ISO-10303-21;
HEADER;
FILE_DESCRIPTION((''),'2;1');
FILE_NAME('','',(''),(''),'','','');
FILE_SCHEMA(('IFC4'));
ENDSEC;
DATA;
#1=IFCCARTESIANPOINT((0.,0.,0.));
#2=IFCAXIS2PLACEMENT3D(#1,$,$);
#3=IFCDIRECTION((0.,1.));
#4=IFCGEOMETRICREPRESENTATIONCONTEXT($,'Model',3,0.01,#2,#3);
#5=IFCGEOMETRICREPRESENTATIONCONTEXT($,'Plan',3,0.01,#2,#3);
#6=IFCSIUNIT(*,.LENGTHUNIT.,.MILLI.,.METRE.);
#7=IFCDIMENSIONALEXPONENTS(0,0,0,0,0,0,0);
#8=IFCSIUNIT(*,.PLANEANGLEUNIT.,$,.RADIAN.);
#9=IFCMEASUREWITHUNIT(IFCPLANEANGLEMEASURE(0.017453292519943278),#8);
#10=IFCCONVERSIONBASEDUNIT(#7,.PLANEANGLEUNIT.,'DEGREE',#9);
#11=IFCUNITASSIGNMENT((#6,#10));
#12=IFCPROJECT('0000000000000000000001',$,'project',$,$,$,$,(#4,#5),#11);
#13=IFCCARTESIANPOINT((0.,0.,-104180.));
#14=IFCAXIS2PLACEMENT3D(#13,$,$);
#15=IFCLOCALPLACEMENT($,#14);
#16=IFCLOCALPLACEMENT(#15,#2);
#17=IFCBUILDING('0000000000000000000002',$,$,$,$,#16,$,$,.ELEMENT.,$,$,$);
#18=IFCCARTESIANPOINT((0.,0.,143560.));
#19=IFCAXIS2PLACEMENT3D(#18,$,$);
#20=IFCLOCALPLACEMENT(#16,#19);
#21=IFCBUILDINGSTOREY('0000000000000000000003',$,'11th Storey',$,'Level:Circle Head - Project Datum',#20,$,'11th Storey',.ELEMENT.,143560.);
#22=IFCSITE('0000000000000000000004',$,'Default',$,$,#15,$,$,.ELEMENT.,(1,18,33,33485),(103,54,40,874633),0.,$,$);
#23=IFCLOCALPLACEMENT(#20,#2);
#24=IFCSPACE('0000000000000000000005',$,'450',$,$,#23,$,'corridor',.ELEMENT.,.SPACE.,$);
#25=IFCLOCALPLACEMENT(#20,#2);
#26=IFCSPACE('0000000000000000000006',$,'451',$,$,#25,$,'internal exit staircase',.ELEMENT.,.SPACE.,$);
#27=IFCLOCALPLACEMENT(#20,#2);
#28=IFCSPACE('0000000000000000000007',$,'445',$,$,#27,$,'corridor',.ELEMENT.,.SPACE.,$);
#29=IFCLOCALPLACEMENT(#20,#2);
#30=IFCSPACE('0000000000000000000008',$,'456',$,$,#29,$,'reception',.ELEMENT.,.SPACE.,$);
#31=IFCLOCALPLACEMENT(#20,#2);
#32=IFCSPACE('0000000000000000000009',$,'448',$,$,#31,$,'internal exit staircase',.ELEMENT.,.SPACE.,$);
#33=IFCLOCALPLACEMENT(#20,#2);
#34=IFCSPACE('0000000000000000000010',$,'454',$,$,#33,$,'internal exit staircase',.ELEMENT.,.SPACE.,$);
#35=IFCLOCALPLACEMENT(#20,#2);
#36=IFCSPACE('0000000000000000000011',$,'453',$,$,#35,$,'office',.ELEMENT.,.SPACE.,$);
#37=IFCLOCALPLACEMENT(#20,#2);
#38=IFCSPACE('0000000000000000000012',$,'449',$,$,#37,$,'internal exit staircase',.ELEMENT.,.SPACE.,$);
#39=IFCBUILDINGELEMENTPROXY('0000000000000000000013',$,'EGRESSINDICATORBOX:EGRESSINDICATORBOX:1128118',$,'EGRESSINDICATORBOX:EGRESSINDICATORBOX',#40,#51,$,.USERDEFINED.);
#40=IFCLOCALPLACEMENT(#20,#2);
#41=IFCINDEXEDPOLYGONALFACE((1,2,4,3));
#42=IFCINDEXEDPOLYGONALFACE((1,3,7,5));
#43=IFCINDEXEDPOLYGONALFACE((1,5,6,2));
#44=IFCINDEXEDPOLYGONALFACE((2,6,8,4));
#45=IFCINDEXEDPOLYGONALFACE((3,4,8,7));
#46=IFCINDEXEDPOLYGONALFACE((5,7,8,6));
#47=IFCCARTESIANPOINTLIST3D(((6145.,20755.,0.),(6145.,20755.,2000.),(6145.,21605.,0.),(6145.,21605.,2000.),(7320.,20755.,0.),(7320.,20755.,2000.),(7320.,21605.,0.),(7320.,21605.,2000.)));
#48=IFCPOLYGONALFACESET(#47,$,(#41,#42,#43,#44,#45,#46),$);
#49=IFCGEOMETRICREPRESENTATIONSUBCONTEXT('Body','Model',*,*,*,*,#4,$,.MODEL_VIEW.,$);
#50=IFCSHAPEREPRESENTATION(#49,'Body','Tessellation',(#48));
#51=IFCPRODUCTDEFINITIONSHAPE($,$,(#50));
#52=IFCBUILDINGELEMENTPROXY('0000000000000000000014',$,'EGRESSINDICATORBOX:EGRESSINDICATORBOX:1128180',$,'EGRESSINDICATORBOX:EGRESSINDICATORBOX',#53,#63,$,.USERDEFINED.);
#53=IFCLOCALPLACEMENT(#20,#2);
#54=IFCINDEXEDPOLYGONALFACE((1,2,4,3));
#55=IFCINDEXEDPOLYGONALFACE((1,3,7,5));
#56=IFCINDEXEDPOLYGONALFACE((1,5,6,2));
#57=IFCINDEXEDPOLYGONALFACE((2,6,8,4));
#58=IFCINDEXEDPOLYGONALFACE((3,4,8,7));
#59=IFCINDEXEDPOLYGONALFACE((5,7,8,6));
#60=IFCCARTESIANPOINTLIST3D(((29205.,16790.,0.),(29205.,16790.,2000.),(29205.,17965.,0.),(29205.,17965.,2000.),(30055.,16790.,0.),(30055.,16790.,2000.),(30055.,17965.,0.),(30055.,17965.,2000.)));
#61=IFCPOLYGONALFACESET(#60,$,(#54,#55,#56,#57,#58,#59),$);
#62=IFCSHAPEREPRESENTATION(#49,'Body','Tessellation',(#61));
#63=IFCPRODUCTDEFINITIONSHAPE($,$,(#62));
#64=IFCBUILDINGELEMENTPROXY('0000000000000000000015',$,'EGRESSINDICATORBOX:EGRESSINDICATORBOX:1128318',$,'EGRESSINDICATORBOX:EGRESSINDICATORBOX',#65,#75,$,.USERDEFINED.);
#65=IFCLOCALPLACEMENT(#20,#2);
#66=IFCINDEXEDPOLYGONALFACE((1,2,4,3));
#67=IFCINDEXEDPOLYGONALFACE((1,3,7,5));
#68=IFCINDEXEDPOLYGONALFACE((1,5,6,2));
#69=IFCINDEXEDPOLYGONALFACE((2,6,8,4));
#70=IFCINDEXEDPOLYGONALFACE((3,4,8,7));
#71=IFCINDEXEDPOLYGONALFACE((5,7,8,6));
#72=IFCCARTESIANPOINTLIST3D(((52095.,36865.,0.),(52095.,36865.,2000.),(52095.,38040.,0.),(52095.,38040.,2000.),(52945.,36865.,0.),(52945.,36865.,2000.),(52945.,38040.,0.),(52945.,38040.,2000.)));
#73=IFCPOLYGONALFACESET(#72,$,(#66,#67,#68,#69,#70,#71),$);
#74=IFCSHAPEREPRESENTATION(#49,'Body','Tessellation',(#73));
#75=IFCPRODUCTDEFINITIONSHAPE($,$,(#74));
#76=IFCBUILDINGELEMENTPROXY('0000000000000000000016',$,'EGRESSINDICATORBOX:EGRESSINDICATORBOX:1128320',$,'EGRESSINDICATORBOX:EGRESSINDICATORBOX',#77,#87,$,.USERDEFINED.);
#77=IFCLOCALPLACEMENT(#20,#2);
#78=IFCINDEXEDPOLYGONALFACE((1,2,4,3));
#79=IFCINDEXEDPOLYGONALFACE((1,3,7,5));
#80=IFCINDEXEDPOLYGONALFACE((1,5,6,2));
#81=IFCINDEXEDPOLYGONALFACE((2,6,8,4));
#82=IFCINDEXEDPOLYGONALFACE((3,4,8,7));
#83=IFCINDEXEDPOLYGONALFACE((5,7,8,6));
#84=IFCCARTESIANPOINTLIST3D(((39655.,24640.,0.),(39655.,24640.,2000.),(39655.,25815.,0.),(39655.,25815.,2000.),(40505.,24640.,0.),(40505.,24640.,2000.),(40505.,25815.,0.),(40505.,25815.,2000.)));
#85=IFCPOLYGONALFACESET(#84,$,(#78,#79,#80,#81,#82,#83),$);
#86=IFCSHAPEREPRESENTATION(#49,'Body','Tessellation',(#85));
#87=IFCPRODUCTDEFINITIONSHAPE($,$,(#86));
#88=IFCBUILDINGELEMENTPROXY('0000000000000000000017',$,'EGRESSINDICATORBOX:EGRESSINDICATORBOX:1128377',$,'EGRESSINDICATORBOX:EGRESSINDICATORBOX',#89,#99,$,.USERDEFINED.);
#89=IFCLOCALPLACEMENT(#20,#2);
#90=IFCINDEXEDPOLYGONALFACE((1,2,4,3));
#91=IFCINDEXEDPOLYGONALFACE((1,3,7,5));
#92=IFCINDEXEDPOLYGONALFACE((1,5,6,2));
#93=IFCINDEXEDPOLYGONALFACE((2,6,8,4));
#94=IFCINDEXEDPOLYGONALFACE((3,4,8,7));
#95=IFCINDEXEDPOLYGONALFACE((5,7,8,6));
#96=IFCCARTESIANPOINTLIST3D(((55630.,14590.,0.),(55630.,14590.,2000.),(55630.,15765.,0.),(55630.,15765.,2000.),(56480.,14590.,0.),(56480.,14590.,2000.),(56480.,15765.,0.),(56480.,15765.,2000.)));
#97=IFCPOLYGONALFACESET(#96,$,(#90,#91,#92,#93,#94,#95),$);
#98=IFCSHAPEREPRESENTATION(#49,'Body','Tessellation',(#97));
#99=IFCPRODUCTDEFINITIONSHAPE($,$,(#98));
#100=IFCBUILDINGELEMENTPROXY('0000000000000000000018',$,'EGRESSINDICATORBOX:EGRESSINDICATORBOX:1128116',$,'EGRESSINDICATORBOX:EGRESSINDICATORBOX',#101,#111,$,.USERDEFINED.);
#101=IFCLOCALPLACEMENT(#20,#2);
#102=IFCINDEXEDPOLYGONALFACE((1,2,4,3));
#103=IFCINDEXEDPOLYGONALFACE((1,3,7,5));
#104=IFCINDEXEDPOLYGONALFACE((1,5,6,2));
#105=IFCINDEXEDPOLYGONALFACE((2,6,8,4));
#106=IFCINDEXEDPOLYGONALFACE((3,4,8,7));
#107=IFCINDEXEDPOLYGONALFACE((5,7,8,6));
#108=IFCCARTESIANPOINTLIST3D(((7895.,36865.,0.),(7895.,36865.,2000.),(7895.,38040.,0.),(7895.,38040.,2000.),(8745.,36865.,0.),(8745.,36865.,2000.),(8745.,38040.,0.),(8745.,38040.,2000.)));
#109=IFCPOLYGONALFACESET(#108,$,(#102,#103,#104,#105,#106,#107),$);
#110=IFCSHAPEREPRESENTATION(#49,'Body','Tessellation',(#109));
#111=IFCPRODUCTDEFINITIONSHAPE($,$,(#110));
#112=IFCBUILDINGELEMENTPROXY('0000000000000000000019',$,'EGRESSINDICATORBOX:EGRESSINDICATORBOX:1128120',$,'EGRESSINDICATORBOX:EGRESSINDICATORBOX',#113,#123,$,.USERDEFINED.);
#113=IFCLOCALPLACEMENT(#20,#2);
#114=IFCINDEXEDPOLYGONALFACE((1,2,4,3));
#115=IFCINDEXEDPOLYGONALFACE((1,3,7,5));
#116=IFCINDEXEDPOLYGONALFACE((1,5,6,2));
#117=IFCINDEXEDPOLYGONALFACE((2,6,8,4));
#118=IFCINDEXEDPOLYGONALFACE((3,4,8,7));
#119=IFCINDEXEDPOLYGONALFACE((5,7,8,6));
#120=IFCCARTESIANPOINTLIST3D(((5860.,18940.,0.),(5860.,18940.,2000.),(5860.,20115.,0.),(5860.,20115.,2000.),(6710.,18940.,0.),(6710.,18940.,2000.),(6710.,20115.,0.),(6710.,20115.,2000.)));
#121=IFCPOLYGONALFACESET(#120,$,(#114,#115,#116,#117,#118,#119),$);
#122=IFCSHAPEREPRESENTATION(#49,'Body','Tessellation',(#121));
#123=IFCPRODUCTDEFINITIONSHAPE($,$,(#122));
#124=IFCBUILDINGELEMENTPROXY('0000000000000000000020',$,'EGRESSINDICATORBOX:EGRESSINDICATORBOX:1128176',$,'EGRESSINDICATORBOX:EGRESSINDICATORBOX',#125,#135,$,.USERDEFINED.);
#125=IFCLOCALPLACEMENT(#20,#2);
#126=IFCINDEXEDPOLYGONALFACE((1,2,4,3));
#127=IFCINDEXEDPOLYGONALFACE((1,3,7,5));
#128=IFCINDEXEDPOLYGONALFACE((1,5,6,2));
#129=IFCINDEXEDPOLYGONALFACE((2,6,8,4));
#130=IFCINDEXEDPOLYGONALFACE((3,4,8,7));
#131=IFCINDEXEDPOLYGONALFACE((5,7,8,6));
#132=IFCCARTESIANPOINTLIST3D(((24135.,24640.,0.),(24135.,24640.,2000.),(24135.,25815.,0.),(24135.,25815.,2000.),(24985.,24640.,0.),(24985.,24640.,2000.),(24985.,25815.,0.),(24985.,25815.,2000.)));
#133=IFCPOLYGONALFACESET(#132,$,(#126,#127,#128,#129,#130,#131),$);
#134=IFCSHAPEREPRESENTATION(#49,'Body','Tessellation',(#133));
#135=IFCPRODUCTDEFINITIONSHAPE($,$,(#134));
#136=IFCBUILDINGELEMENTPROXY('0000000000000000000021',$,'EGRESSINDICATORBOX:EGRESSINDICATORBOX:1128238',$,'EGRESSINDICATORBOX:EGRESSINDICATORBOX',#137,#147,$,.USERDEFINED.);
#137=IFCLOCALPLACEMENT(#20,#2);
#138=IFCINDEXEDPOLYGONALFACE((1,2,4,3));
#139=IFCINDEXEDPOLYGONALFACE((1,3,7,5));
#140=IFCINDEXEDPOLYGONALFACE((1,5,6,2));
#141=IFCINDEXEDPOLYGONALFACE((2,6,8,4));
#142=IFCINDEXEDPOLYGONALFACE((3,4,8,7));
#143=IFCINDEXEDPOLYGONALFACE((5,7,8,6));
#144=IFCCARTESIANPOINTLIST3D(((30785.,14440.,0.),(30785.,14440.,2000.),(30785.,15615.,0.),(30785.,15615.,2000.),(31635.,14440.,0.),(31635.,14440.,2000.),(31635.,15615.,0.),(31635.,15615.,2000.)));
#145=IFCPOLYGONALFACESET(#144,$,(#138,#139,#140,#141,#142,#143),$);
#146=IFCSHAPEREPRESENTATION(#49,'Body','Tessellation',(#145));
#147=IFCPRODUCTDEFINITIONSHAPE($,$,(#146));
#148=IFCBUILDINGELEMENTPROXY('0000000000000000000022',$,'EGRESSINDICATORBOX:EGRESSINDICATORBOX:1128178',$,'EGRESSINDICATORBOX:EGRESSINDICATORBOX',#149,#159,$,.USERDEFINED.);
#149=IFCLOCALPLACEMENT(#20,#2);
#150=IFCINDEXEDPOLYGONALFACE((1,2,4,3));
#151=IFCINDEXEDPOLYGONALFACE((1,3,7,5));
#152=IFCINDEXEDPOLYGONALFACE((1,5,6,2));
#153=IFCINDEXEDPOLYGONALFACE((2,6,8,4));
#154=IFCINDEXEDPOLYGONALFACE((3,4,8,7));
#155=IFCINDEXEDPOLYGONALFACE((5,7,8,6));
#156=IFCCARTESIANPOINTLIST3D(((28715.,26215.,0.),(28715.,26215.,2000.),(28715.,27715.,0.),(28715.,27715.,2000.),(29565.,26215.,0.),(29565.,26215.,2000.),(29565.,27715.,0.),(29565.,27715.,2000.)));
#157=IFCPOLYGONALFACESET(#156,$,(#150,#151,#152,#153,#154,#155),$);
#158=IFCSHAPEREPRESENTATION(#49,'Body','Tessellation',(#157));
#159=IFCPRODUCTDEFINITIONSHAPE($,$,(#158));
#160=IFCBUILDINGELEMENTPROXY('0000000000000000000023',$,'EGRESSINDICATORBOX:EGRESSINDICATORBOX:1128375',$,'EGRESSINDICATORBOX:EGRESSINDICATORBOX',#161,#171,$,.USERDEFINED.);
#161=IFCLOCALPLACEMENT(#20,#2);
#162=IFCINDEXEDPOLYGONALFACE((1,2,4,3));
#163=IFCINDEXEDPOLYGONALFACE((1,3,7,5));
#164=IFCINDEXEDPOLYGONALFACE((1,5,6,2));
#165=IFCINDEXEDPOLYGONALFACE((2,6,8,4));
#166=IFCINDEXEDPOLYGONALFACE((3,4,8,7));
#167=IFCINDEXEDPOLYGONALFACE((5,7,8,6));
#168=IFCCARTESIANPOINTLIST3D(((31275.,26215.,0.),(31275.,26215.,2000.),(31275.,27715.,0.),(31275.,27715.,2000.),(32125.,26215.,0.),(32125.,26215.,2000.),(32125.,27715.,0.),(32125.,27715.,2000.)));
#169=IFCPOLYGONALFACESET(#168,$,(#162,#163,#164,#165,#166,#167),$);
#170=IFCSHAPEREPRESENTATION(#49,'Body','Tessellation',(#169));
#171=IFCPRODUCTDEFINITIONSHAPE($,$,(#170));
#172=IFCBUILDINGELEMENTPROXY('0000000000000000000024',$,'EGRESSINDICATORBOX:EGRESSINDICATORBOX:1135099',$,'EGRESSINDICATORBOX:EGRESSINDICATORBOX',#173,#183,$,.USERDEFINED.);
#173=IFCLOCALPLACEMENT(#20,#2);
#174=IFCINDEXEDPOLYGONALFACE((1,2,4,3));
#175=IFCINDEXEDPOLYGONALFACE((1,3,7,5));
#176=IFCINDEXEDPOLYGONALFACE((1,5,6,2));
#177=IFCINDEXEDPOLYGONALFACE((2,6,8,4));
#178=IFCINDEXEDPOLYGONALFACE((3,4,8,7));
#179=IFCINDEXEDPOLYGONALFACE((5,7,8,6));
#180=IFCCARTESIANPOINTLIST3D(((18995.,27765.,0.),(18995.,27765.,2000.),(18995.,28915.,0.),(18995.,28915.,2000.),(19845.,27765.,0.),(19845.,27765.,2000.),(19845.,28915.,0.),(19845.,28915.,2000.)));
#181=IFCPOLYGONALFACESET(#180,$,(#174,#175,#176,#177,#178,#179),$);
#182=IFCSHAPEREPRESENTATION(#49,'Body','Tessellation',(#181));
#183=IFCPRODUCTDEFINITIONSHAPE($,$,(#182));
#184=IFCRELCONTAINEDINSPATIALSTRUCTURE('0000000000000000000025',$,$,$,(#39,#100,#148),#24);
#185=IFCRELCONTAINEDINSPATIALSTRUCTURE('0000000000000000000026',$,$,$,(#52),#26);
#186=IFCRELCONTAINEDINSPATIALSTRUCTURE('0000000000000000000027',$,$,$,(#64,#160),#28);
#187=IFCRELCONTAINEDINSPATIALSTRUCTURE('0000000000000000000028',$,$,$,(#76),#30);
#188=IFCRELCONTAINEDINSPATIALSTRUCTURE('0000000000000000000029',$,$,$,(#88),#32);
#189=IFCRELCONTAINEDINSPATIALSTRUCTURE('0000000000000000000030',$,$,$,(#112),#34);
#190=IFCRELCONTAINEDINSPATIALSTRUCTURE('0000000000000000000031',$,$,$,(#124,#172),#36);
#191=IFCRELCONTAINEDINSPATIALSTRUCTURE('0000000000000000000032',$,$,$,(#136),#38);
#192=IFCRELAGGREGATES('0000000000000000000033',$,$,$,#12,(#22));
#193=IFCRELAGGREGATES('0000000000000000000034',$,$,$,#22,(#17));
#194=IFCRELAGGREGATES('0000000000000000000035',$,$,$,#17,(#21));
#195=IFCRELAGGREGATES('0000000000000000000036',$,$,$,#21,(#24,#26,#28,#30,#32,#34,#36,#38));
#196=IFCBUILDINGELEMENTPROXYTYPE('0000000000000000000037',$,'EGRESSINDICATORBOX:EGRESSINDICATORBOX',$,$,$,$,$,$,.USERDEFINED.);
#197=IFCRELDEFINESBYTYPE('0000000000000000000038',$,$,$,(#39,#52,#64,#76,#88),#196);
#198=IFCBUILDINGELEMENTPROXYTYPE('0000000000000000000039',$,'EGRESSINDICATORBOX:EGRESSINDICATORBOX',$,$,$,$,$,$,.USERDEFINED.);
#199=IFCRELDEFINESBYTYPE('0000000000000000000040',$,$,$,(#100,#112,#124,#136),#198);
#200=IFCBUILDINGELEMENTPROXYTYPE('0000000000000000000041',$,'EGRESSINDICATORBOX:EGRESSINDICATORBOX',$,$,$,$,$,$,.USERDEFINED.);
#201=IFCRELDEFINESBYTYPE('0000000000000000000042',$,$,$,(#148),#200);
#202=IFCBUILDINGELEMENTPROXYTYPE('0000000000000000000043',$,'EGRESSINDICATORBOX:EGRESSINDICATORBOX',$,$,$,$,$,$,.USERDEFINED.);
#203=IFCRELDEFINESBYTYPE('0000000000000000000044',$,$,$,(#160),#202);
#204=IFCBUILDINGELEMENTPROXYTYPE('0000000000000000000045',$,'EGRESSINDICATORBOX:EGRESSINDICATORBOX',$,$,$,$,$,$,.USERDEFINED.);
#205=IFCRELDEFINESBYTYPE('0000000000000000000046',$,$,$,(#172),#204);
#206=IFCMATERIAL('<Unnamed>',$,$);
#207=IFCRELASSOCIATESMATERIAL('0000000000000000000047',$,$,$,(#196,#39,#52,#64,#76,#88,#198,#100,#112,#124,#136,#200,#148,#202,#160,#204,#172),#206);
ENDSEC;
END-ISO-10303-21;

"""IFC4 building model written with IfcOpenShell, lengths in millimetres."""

from ifc_helpers import new_model, entity, si_unit, converted_unit, direction, frame, origin, place, context, subcontext, project, spatial, indexed_curve, outline, extrude, source, transform, mapped, material, type_object, type_shapes, element, save


model = new_model("IFC4")

# Units and contexts
model_context = context("Model", 3, precision=0.01, world=origin(), true_north=direction((0.0, 1.0)))
plan_context = context("Plan", 3, precision=0.01, world=origin(), true_north=direction((0.0, 1.0)))
body_context = subcontext(model_context, "Body", "Model", "MODEL_VIEW")
ifc_project = project(units=[si_unit("LENGTHUNIT", "METRE", prefix="MILLI"), converted_unit("PLANEANGLEUNIT", "DEGREE", entity("IfcPlaneAngleMeasure", 0.017453292519943278), si_unit("PLANEANGLEUNIT", "RADIAN"), dimensions=[0, 0, 0, 0, 0, 0, 0])], contexts=[model_context, plan_context])

# Site, building, storey
site_placement = place(None, frame((0.0, 0.0, -104180.0)))
site = spatial("IfcSite", under=ifc_project, at=site_placement, Name="Default", CompositionType="ELEMENT", RefLatitude=(1, 18, 33, 33485), RefLongitude=(103, 54, 40, 874633), RefElevation=0.0)
building_placement = place(site_placement, origin())
building = spatial("IfcBuilding", under=site, at=building_placement, CompositionType="ELEMENT")
storey_placement = place(building_placement, frame((0.0, 0.0, 143560.0)))
storey = spatial("IfcBuildingStorey", under=building, at=storey_placement, Name="11th Storey", ObjectType="Level:Circle Head - Project Datum", LongName="11th Storey", CompositionType="ELEMENT", Elevation=143560.0)

# Shared definitions
space_1_placement = place(storey_placement, origin())
space_1 = spatial("IfcSpace", under=storey, at=space_1_placement, Name="450", LongName="corridor", CompositionType="ELEMENT", PredefinedType="SPACE")

# Building element proxy
ifc_material_1 = material(Name="<Unnamed>")
building_element_proxy_type_1 = type_object("IfcBuildingElementProxyType", Name="EGRESSINDICATORBOX:EGRESSINDICATORBOX", PredefinedType="USERDEFINED", material=ifc_material_1)
shared_shape_1 = source(origin(), body_context, "Body", "SweptSolid", [
    extrude(outline(indexed_curve([(-587.5, -425.0), (587.5, -425.0), (587.5, 425.0), (-587.5, 425.0), (-587.5, -425.0)], self_intersect=False)), frame((0.0, 0.0, 0.0), z_axis=(0.0, 0.0, 1.0), x_axis=(0.0, 1.0, 0.0)), (0.0, 0.0, 1.0), 2000.0),
])
type_shapes(building_element_proxy_type_1, [shared_shape_1])
proxy_1_placement = place(space_1_placement, frame((6732.5, 21180.0, 0.0), z_axis=(0.0, 0.0, 1.0), x_axis=(0.0, -1.0, 0.0)))
element("IfcBuildingElementProxy", 1, at=proxy_1_placement, inside=space_1, type_object=building_element_proxy_type_1, material=ifc_material_1, Name="EGRESSINDICATORBOX:EGRESSINDICATORBOX:1128118", ObjectType="EGRESSINDICATORBOX:EGRESSINDICATORBOX", PredefinedType="USERDEFINED", context=body_context, shape_type="MappedRepresentation", body=[
    mapped(shared_shape_1, transform((0.0, 0.0, 0.0), scale=1.0)),
])

# Shared definitions
space_2_placement = place(storey_placement, origin())
space_2 = spatial("IfcSpace", under=storey, at=space_2_placement, Name="451", LongName="internal exit staircase", CompositionType="ELEMENT", PredefinedType="SPACE")

# Building element proxy
proxy_2_placement = place(space_2_placement, frame((29630.0, 17377.5, 0.0)))
element("IfcBuildingElementProxy", 2, at=proxy_2_placement, inside=space_2, type_object=building_element_proxy_type_1, material=ifc_material_1, Name="EGRESSINDICATORBOX:EGRESSINDICATORBOX:1128180", ObjectType="EGRESSINDICATORBOX:EGRESSINDICATORBOX", PredefinedType="USERDEFINED", context=body_context, shape_type="MappedRepresentation", body=[
    mapped(shared_shape_1, transform((0.0, 0.0, 0.0), scale=1.0)),
])

# Shared definitions
space_3_placement = place(storey_placement, origin())
space_3 = spatial("IfcSpace", under=storey, at=space_3_placement, Name="445", LongName="corridor", CompositionType="ELEMENT", PredefinedType="SPACE")

# Building element proxy
proxy_3_placement = place(space_3_placement, frame((52520.0, 37452.5, 0.0), z_axis=(0.0, 0.0, 1.0), x_axis=(-1.0, 0.0, 0.0)))
element("IfcBuildingElementProxy", 3, at=proxy_3_placement, inside=space_3, type_object=building_element_proxy_type_1, material=ifc_material_1, Name="EGRESSINDICATORBOX:EGRESSINDICATORBOX:1128318", ObjectType="EGRESSINDICATORBOX:EGRESSINDICATORBOX", PredefinedType="USERDEFINED", context=body_context, shape_type="MappedRepresentation", body=[
    mapped(shared_shape_1, transform((0.0, 0.0, 0.0), scale=1.0)),
])

# Shared definitions
space_4_placement = place(storey_placement, origin())
space_4 = spatial("IfcSpace", under=storey, at=space_4_placement, Name="456", LongName="reception", CompositionType="ELEMENT", PredefinedType="SPACE")

# Building element proxy
proxy_4_placement = place(space_4_placement, frame((40080.0, 25227.5, 0.0), z_axis=(0.0, 0.0, 1.0), x_axis=(-1.0, 0.0, 0.0)))
element("IfcBuildingElementProxy", 4, at=proxy_4_placement, inside=space_4, type_object=building_element_proxy_type_1, material=ifc_material_1, Name="EGRESSINDICATORBOX:EGRESSINDICATORBOX:1128320", ObjectType="EGRESSINDICATORBOX:EGRESSINDICATORBOX", PredefinedType="USERDEFINED", context=body_context, shape_type="MappedRepresentation", body=[
    mapped(shared_shape_1, transform((0.0, 0.0, 0.0), scale=1.0)),
])

# Shared definitions
space_5_placement = place(storey_placement, origin())
space_5 = spatial("IfcSpace", under=storey, at=space_5_placement, Name="448", LongName="internal exit staircase", CompositionType="ELEMENT", PredefinedType="SPACE")

# Building element proxies
proxy_5_placement = place(space_5_placement, frame((56055.0, 15177.5, 0.0)))
element("IfcBuildingElementProxy", 5, at=proxy_5_placement, inside=space_5, type_object=building_element_proxy_type_1, material=ifc_material_1, Name="EGRESSINDICATORBOX:EGRESSINDICATORBOX:1128377", ObjectType="EGRESSINDICATORBOX:EGRESSINDICATORBOX", PredefinedType="USERDEFINED", context=body_context, shape_type="MappedRepresentation", body=[
    mapped(shared_shape_1, transform((0.0, 0.0, 0.0), scale=1.0)),
])
building_element_proxy_type_2 = type_object("IfcBuildingElementProxyType", Name="EGRESSINDICATORBOX:EGRESSINDICATORBOX", PredefinedType="USERDEFINED", material=ifc_material_1)
shared_shape_2 = source(origin(), body_context, "Body", "SweptSolid", [
    extrude(outline(indexed_curve([(-425.0, -587.5), (425.0, -587.5), (425.0, 587.5), (-425.0, 587.5), (-425.0, -587.5)], self_intersect=False)), frame((0.0, 0.0, 0.0), z_axis=(0.0, 0.0, 1.0), x_axis=(-1.0, 0.0, 0.0)), (0.0, 0.0, 1.0), 2000.0),
])
type_shapes(building_element_proxy_type_2, [shared_shape_2])
proxy_6_placement = place(space_1_placement, frame((8320.0, 37452.5, 0.0)))
element("IfcBuildingElementProxy", 6, at=proxy_6_placement, inside=space_1, type_object=building_element_proxy_type_2, material=ifc_material_1, Name="EGRESSINDICATORBOX:EGRESSINDICATORBOX:1128116", ObjectType="EGRESSINDICATORBOX:EGRESSINDICATORBOX", PredefinedType="USERDEFINED", context=body_context, shape_type="MappedRepresentation", body=[
    mapped(shared_shape_2, transform((0.0, 0.0, 0.0), scale=1.0)),
])

# Shared definitions
space_6_placement = place(storey_placement, origin())
space_6 = spatial("IfcSpace", under=storey, at=space_6_placement, Name="454", LongName="internal exit staircase", CompositionType="ELEMENT", PredefinedType="SPACE")

# Building element proxy
proxy_7_placement = place(space_6_placement, frame((6285.0, 19527.5, 0.0), z_axis=(0.0, 0.0, 1.0), x_axis=(-1.0, 0.0, 0.0)))
element("IfcBuildingElementProxy", 7, at=proxy_7_placement, inside=space_6, type_object=building_element_proxy_type_2, material=ifc_material_1, Name="EGRESSINDICATORBOX:EGRESSINDICATORBOX:1128120", ObjectType="EGRESSINDICATORBOX:EGRESSINDICATORBOX", PredefinedType="USERDEFINED", context=body_context, shape_type="MappedRepresentation", body=[
    mapped(shared_shape_2, transform((0.0, 0.0, 0.0), scale=1.0)),
])

# Shared definitions
space_7_placement = place(storey_placement, origin())
space_7 = spatial("IfcSpace", under=storey, at=space_7_placement, Name="453", LongName="office", CompositionType="ELEMENT", PredefinedType="SPACE")

# Building element proxy
proxy_8_placement = place(space_7_placement, frame((24560.0, 25227.5, 0.0)))
element("IfcBuildingElementProxy", 8, at=proxy_8_placement, inside=space_7, type_object=building_element_proxy_type_2, material=ifc_material_1, Name="EGRESSINDICATORBOX:EGRESSINDICATORBOX:1128176", ObjectType="EGRESSINDICATORBOX:EGRESSINDICATORBOX", PredefinedType="USERDEFINED", context=body_context, shape_type="MappedRepresentation", body=[
    mapped(shared_shape_2, transform((0.0, 0.0, 0.0), scale=1.0)),
])

# Shared definitions
space_8_placement = place(storey_placement, origin())
space_8 = spatial("IfcSpace", under=storey, at=space_8_placement, Name="449", LongName="internal exit staircase", CompositionType="ELEMENT", PredefinedType="SPACE")

# Building element proxies
proxy_9_placement = place(space_8_placement, frame((31210.0, 15027.5, 0.0), z_axis=(0.0, 0.0, 1.0), x_axis=(-1.0, 0.0, 0.0)))
element("IfcBuildingElementProxy", 9, at=proxy_9_placement, inside=space_8, type_object=building_element_proxy_type_2, material=ifc_material_1, Name="EGRESSINDICATORBOX:EGRESSINDICATORBOX:1128238", ObjectType="EGRESSINDICATORBOX:EGRESSINDICATORBOX", PredefinedType="USERDEFINED", context=body_context, shape_type="MappedRepresentation", body=[
    mapped(shared_shape_2, transform((0.0, 0.0, 0.0), scale=1.0)),
])
building_element_proxy_type_3 = type_object("IfcBuildingElementProxyType", Name="EGRESSINDICATORBOX:EGRESSINDICATORBOX", PredefinedType="USERDEFINED", material=ifc_material_1)
shared_shape_3 = source(origin(), body_context, "Body", "SweptSolid", [
    extrude(outline(indexed_curve([(-425.0, -750.0), (425.0, -750.0), (425.0, 750.0), (-425.0, 750.0), (-425.0, -750.0)], self_intersect=False)), frame((0.0, 0.0, 0.0), z_axis=(0.0, 0.0, 1.0), x_axis=(-1.0, 0.0, 0.0)), (0.0, 0.0, 1.0), 2000.0),
])
type_shapes(building_element_proxy_type_3, [shared_shape_3])
proxy_10_placement = place(space_1_placement, frame((29140.0, 26965.0, 0.0)))
element("IfcBuildingElementProxy", 10, at=proxy_10_placement, inside=space_1, type_object=building_element_proxy_type_3, material=ifc_material_1, Name="EGRESSINDICATORBOX:EGRESSINDICATORBOX:1128178", ObjectType="EGRESSINDICATORBOX:EGRESSINDICATORBOX", PredefinedType="USERDEFINED", context=body_context, shape_type="MappedRepresentation", body=[
    mapped(shared_shape_3, transform((0.0, 0.0, 0.0), scale=1.0)),
])
building_element_proxy_type_4 = type_object("IfcBuildingElementProxyType", Name="EGRESSINDICATORBOX:EGRESSINDICATORBOX", PredefinedType="USERDEFINED", material=ifc_material_1)
shared_shape_4 = source(origin(), body_context, "Body", "SweptSolid", [
    extrude(outline(indexed_curve([(-750.0, -425.0), (750.0, -425.0), (750.0, 425.0), (-750.0, 425.0), (-750.0, -425.0)], self_intersect=False)), frame((0.0, 0.0, 0.0), z_axis=(0.0, 0.0, 1.0), x_axis=(0.0, 1.0, 0.0)), (0.0, 0.0, 1.0), 2000.0),
])
type_shapes(building_element_proxy_type_4, [shared_shape_4])
proxy_11_placement = place(space_3_placement, frame((31700.0, 26965.0, 0.0), z_axis=(0.0, 0.0, 1.0), x_axis=(-1.0, 0.0, 0.0)))
element("IfcBuildingElementProxy", 11, at=proxy_11_placement, inside=space_3, type_object=building_element_proxy_type_4, material=ifc_material_1, Name="EGRESSINDICATORBOX:EGRESSINDICATORBOX:1128375", ObjectType="EGRESSINDICATORBOX:EGRESSINDICATORBOX", PredefinedType="USERDEFINED", context=body_context, shape_type="MappedRepresentation", body=[
    mapped(shared_shape_4, transform((0.0, 0.0, 0.0), scale=1.0)),
])
building_element_proxy_type_5 = type_object("IfcBuildingElementProxyType", Name="EGRESSINDICATORBOX:EGRESSINDICATORBOX", PredefinedType="USERDEFINED", material=ifc_material_1)
shared_shape_5 = source(origin(), body_context, "Body", "SweptSolid", [
    extrude(outline(indexed_curve([(-425.0, -575.0), (425.0, -575.0), (425.0, 575.0), (-425.0, 575.0), (-425.0, -575.0)], self_intersect=False)), frame((0.0, 0.0, 0.0), z_axis=(0.0, 0.0, 1.0), x_axis=(-1.0, 0.0, 0.0)), (0.0, 0.0, 1.0), 2000.0),
])
type_shapes(building_element_proxy_type_5, [shared_shape_5])
proxy_12_placement = place(space_7_placement, frame((19420.0, 28340.0, 0.0)))
element("IfcBuildingElementProxy", 12, at=proxy_12_placement, inside=space_7, type_object=building_element_proxy_type_5, material=ifc_material_1, Name="EGRESSINDICATORBOX:EGRESSINDICATORBOX:1135099", ObjectType="EGRESSINDICATORBOX:EGRESSINDICATORBOX", PredefinedType="USERDEFINED", context=body_context, shape_type="MappedRepresentation", body=[
    mapped(shared_shape_5, transform((0.0, 0.0, 0.0), scale=1.0)),
])

save(model, "model.ifc")
